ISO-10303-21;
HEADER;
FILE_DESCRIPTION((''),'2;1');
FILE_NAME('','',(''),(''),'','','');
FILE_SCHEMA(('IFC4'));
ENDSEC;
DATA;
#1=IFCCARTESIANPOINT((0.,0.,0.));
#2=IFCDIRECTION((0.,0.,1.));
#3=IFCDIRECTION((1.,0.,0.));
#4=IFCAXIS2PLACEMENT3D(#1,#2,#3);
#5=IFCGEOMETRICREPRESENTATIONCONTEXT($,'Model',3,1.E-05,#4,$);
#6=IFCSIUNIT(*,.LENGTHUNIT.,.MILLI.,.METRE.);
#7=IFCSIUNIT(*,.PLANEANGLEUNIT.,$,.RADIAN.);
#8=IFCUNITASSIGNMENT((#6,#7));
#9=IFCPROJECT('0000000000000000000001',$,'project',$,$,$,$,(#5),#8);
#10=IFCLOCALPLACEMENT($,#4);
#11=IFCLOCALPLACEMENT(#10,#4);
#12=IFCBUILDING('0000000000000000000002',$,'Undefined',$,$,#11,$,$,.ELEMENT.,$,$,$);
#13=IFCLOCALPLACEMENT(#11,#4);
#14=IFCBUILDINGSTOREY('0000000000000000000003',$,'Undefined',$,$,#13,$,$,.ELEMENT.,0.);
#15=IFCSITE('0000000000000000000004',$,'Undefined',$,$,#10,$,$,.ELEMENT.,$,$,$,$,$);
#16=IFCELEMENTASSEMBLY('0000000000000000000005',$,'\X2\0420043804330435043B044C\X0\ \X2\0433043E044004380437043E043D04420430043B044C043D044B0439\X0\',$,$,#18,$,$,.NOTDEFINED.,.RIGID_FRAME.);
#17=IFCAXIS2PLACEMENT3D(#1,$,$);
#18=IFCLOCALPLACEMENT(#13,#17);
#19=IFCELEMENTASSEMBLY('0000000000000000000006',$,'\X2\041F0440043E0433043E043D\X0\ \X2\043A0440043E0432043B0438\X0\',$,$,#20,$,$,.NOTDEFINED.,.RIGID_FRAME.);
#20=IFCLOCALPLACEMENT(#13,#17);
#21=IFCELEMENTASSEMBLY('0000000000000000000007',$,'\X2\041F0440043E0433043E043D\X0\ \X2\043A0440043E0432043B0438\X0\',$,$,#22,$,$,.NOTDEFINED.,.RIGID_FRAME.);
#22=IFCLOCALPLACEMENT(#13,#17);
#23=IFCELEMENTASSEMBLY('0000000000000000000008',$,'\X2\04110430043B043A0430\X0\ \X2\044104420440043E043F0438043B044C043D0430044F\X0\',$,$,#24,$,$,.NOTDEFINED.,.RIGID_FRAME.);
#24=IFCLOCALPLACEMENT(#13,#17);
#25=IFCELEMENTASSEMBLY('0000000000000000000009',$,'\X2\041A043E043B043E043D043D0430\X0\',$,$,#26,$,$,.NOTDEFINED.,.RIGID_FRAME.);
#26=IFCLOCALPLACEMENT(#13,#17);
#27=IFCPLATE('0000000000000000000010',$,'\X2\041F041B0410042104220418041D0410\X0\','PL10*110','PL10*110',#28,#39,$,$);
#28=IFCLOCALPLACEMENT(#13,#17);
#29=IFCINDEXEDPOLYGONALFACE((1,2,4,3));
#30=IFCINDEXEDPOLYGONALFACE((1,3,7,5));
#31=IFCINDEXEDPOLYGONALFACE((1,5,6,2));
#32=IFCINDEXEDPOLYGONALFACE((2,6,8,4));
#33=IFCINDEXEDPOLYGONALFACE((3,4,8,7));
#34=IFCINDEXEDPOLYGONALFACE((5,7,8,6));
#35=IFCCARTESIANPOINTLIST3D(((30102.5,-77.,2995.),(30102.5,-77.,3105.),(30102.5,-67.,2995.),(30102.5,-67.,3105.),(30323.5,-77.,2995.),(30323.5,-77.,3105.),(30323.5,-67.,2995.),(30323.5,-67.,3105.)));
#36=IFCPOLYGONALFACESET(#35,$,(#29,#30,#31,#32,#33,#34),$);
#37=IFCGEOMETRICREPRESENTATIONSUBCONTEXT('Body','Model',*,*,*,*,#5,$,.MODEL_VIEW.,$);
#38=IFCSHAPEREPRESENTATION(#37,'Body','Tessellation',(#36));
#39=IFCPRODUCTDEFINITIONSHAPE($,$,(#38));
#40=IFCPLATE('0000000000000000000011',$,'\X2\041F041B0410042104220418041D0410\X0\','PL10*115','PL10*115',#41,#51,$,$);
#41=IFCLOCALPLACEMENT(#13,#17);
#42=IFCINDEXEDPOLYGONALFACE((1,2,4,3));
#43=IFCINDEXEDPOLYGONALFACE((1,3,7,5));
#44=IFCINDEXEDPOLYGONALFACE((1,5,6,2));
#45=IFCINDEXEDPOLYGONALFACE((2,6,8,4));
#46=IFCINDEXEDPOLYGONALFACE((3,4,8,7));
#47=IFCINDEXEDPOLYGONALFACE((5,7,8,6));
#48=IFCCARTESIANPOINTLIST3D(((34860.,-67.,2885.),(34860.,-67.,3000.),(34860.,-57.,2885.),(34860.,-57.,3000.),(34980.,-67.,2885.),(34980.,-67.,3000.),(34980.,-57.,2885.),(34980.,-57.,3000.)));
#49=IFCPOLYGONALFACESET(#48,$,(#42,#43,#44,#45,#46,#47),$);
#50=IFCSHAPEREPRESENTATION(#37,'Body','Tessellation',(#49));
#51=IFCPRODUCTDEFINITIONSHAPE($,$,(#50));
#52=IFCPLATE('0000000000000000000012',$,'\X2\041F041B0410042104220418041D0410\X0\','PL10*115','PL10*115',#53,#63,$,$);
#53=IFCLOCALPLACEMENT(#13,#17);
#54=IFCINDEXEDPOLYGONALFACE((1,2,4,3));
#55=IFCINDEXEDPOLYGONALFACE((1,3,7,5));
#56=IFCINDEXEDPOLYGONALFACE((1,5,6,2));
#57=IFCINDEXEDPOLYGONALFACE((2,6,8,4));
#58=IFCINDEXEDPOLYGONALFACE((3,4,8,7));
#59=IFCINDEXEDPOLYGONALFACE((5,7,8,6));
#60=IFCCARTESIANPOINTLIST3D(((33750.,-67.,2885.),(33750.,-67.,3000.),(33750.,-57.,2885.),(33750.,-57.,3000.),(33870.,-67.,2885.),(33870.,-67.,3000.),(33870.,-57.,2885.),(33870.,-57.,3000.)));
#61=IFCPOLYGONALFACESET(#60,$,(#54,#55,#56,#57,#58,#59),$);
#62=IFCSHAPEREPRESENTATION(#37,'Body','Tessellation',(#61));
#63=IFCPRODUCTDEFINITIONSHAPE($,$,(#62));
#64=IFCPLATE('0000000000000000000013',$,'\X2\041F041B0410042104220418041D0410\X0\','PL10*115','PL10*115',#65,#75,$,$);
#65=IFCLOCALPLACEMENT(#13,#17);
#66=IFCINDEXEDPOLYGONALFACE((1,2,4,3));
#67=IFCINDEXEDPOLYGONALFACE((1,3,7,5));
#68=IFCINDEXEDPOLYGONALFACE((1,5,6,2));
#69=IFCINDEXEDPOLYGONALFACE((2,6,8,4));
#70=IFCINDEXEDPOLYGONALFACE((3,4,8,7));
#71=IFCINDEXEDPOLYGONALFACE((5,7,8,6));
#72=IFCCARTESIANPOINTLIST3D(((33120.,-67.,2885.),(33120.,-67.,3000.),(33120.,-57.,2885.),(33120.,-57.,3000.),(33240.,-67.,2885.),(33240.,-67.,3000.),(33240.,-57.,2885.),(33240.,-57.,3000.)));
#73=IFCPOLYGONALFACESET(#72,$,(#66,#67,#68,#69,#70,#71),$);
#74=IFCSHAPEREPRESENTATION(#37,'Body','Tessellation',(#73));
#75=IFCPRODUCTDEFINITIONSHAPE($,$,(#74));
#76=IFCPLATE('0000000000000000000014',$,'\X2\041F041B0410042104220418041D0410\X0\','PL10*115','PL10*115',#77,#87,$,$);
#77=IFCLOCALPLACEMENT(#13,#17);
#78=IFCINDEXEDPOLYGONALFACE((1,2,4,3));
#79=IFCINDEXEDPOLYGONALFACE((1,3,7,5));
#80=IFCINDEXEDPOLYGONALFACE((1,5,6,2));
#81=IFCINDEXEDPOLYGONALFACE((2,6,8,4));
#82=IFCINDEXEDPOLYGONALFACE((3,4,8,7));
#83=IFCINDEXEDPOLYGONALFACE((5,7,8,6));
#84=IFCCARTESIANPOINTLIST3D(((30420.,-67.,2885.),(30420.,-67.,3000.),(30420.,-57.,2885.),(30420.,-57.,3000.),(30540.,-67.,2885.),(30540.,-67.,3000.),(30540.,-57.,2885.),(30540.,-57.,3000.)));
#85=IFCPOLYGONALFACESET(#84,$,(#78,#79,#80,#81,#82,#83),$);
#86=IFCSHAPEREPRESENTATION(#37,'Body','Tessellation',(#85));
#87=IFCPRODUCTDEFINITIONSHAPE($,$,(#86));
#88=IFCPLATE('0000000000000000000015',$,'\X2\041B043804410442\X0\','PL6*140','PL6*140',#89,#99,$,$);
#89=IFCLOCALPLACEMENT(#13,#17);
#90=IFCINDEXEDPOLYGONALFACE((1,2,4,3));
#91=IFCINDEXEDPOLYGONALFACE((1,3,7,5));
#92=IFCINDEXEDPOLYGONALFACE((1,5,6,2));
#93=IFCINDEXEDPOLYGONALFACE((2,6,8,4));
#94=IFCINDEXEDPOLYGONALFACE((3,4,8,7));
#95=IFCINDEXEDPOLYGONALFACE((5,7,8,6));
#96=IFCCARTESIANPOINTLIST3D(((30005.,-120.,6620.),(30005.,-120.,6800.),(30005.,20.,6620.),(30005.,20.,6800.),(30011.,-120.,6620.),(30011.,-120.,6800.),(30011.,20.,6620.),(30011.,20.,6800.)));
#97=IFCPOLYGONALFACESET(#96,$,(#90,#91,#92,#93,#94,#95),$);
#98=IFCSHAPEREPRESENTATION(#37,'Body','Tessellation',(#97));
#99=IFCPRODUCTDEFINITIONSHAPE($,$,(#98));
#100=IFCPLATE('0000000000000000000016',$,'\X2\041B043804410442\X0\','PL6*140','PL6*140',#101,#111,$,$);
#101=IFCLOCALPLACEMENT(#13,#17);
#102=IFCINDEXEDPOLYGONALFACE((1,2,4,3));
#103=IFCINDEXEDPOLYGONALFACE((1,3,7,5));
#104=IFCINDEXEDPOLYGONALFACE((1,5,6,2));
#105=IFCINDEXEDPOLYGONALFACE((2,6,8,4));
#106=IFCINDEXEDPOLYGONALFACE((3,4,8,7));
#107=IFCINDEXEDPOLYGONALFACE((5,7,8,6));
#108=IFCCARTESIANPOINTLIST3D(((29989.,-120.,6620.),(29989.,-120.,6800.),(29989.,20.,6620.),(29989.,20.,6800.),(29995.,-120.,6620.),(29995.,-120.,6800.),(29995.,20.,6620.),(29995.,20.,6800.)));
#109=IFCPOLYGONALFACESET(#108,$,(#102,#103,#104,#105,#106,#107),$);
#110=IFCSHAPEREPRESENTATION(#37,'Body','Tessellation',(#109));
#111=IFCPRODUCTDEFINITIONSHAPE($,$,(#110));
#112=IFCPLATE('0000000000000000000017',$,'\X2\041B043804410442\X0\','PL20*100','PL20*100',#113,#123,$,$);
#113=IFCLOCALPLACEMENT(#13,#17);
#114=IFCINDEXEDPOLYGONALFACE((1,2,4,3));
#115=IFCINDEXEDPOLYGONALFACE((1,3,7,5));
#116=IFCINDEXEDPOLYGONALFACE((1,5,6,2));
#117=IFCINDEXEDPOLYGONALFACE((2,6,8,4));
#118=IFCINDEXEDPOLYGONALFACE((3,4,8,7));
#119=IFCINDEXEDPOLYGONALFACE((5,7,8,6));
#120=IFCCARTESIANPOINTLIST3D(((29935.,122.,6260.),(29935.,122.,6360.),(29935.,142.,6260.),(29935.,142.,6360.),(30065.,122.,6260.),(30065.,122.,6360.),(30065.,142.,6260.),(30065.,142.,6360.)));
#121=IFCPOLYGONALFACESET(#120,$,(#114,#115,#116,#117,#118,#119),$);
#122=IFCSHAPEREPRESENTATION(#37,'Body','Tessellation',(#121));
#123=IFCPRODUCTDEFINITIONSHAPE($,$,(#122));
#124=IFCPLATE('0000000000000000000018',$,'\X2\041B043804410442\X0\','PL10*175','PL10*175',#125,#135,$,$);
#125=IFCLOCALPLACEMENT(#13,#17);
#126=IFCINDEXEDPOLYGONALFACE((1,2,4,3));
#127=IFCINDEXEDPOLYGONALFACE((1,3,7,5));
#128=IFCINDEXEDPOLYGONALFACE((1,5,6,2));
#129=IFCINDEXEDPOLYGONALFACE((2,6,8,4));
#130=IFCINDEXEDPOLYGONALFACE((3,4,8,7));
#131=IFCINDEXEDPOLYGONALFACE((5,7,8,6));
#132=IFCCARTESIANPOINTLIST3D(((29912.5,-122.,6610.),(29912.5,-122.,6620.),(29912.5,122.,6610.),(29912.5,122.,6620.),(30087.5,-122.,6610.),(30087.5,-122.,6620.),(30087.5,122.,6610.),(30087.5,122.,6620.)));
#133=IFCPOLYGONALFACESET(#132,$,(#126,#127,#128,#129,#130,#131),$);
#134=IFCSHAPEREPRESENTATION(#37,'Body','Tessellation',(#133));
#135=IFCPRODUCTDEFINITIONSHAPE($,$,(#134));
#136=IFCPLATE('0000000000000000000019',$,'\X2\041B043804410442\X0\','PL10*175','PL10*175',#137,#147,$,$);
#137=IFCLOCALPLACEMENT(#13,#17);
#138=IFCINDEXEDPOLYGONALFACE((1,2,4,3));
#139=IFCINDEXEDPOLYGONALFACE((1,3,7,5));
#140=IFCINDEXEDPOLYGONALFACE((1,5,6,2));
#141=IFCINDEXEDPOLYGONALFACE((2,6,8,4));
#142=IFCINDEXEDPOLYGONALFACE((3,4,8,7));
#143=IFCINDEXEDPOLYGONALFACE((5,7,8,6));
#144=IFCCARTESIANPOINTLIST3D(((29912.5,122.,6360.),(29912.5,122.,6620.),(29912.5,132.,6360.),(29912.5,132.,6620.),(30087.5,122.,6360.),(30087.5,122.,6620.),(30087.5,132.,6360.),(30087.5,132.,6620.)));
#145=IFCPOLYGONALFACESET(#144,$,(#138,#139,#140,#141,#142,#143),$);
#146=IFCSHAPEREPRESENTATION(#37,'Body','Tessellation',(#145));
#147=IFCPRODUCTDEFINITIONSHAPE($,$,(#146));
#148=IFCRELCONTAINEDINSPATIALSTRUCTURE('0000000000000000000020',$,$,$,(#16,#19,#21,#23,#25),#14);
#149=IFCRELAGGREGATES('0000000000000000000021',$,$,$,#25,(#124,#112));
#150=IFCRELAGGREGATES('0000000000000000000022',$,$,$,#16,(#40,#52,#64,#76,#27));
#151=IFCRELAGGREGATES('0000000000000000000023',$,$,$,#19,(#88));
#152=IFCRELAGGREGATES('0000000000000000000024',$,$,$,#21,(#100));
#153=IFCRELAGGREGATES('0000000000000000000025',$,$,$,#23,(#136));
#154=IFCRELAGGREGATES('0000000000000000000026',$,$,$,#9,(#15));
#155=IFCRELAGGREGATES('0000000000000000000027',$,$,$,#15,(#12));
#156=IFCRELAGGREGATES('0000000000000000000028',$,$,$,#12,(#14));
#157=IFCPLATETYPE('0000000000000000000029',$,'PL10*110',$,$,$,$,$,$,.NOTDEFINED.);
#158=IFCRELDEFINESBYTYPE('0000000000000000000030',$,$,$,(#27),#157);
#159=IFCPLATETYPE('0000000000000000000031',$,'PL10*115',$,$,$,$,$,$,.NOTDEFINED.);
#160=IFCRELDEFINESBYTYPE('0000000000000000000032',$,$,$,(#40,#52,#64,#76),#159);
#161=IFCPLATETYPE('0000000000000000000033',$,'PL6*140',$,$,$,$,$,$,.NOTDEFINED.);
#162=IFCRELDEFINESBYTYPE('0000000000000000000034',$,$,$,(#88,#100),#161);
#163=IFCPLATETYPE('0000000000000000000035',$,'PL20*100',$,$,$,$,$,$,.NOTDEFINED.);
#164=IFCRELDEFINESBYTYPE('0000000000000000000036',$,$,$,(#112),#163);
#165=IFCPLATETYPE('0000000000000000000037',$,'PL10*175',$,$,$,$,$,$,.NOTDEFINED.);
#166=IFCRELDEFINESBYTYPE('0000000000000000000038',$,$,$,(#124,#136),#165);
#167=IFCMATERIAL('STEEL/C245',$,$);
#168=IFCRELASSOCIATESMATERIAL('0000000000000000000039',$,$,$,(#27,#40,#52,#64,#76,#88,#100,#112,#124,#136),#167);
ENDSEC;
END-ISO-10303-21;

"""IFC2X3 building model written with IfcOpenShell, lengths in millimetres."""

from ifc_helpers import new_model, si_unit, frame, origin_with_axes, place, context, subcontext, project, spatial, polyline, outline, extrude, material, type_object, element, aggregate, save


model = new_model("IFC2X3")

# Units and contexts
model_context = context("Model", 3, precision=1e-05, world=origin_with_axes())
body_context = subcontext(model_context, "Body", "Model", "MODEL_VIEW")
ifc_project = project(units=[si_unit("LENGTHUNIT", "METRE", prefix="MILLI"), si_unit("PLANEANGLEUNIT", "RADIAN")], contexts=[model_context])

# Site, building, storey
site_placement = place(None, origin_with_axes())
site = spatial("IfcSite", under=ifc_project, at=site_placement, Name="Undefined", CompositionType="ELEMENT")
building_placement = place(site_placement, origin_with_axes())
building = spatial("IfcBuilding", under=site, at=building_placement, Name="Undefined", CompositionType="ELEMENT")
storey_placement = place(building_placement, origin_with_axes())
storey = spatial("IfcBuildingStorey", under=building, at=storey_placement, Name="Undefined", CompositionType="ELEMENT", Elevation=0.0)

# Element assemblies
assembly_1_placement = place(storey_placement, origin_with_axes())
assembly_1 = element("IfcElementAssembly", 1, at=assembly_1_placement, inside=storey, Name="Ригель горизонтальный", AssemblyPlace="NOTDEFINED", PredefinedType="RIGID_FRAME")
ifc_material_1 = material(Name="STEEL/C245")
assembly_2_placement = place(storey_placement, origin_with_axes())
assembly_2 = element("IfcElementAssembly", 2, at=assembly_2_placement, inside=storey, Name="Прогон кровли", AssemblyPlace="NOTDEFINED", PredefinedType="RIGID_FRAME")
assembly_3_placement = place(storey_placement, origin_with_axes())
assembly_3 = element("IfcElementAssembly", 3, at=assembly_3_placement, inside=storey, Name="Прогон кровли", AssemblyPlace="NOTDEFINED", PredefinedType="RIGID_FRAME")

# Element assembly
assembly_4_placement = place(storey_placement, origin_with_axes())
assembly_4 = element("IfcElementAssembly", 4, at=assembly_4_placement, inside=storey, Name="Балка стропильная", AssemblyPlace="NOTDEFINED", PredefinedType="RIGID_FRAME")

# Element assembly
assembly_5_placement = place(storey_placement, origin_with_axes())
assembly_5 = element("IfcElementAssembly", 5, at=assembly_5_placement, inside=storey, Name="Колонна", AssemblyPlace="NOTDEFINED", PredefinedType="RIGID_FRAME")

# Shared definitions
plate_type_1 = type_object("IfcPlateType", Name="PL10*110", PredefinedType="NOTDEFINED")

# Plates
plate_1_placement = place(assembly_1_placement, frame((30102.5, -72.0, 3050.0), z_axis=(0.0, -1.0, 0.0), x_axis=(1.0, 0.0, 0.0)))
plate_1 = element("IfcPlate", 6, at=plate_1_placement, type_object=plate_type_1, material=ifc_material_1, Name="ПЛАСТИНА", Description="PL10*110", ObjectType="PL10*110", context=body_context, shape_type="SweptSolid", body=[
    extrude(outline(polyline([(0.0, -55.0), (0.0, 55.0), (221.0, 55.0), (221.0, -55.0), (0.0, -55.0)])), frame((0.0, 0.0, -5.0), z_axis=(0.0, 0.0, 1.0), x_axis=(1.0, 0.0, 0.0)), (0.0, 0.0, 1.0), 10.0),
])
plate_type_2 = type_object("IfcPlateType", Name="PL10*115", PredefinedType="NOTDEFINED")
plate_2_placement = place(assembly_1_placement, frame((34860.0, -62.0, 3000.0), z_axis=(0.0, -1.0, 0.0), x_axis=(0.0, 0.0, -1.0)))
plate_2 = element("IfcPlate", 7, at=plate_2_placement, type_object=plate_type_2, material=ifc_material_1, Name="ПЛАСТИНА", Description="PL10*115", ObjectType="PL10*115", context=body_context, shape_type="SweptSolid", body=[
    extrude(outline(polyline([(0.0, 0.0), (115.0, 0.0), (115.0, 120.0), (0.0, 120.0), (0.0, 0.0)])), frame((0.0, 0.0, -5.0), z_axis=(0.0, 0.0, 1.0), x_axis=(1.0, 0.0, 0.0)), (0.0, 0.0, 1.0), 10.0),
])
plate_3_placement = place(assembly_1_placement, frame((33750.0, -62.0, 3000.0), z_axis=(0.0, -1.0, 0.0), x_axis=(0.0, 0.0, -1.0)))
plate_3 = element("IfcPlate", 8, at=plate_3_placement, type_object=plate_type_2, material=ifc_material_1, Name="ПЛАСТИНА", Description="PL10*115", ObjectType="PL10*115", context=body_context, shape_type="SweptSolid", body=[
    extrude(outline(polyline([(0.0, 0.0), (115.0, 0.0), (115.0, 120.0), (0.0, 120.0), (0.0, 0.0)])), frame((0.0, 0.0, -5.0), z_axis=(0.0, 0.0, 1.0), x_axis=(1.0, 0.0, 0.0)), (0.0, 0.0, 1.0), 10.0),
])
plate_4_placement = place(assembly_1_placement, frame((33120.0, -62.0, 3000.0), z_axis=(0.0, -1.0, 0.0), x_axis=(0.0, 0.0, -1.0)))
plate_4 = element("IfcPlate", 9, at=plate_4_placement, type_object=plate_type_2, material=ifc_material_1, Name="ПЛАСТИНА", Description="PL10*115", ObjectType="PL10*115", context=body_context, shape_type="SweptSolid", body=[
    extrude(outline(polyline([(0.0, 0.0), (115.0, 0.0), (115.0, 120.0), (0.0, 120.0), (0.0, 0.0)])), frame((0.0, 0.0, -5.0), z_axis=(0.0, 0.0, 1.0), x_axis=(1.0, 0.0, 0.0)), (0.0, 0.0, 1.0), 10.0),
])
plate_5_placement = place(assembly_1_placement, frame((30420.0, -62.0, 3000.0), z_axis=(0.0, -1.0, 0.0), x_axis=(0.0, 0.0, -1.0)))
plate_5 = element("IfcPlate", 10, at=plate_5_placement, type_object=plate_type_2, material=ifc_material_1, Name="ПЛАСТИНА", Description="PL10*115", ObjectType="PL10*115", context=body_context, shape_type="SweptSolid", body=[
    extrude(outline(polyline([(0.0, 0.0), (115.0, 0.0), (115.0, 120.0), (0.0, 120.0), (0.0, 0.0)])), frame((0.0, 0.0, -5.0), z_axis=(0.0, 0.0, 1.0), x_axis=(1.0, 0.0, 0.0)), (0.0, 0.0, 1.0), 10.0),
])
plate_type_3 = type_object("IfcPlateType", Name="PL6*140", PredefinedType="NOTDEFINED")
plate_6_placement = place(assembly_2_placement, frame((30008.0, -50.0, 6620.0), z_axis=(1.0, 0.0, 0.0), x_axis=(0.0, 0.0, 1.0)))
plate_6 = element("IfcPlate", 11, at=plate_6_placement, type_object=plate_type_3, material=ifc_material_1, Name="Лист", Description="PL6*140", ObjectType="PL6*140", context=body_context, shape_type="SweptSolid", body=[
    extrude(outline(polyline([(0.0, 70.0), (180.0, 70.0), (180.0, -70.0), (0.0, -70.0), (0.0, 70.0)])), frame((0.0, 0.0, -3.0), z_axis=(0.0, 0.0, 1.0), x_axis=(1.0, 0.0, 0.0)), (0.0, 0.0, 1.0), 6.0),
])
plate_7_placement = place(assembly_3_placement, frame((29992.0, -50.0, 6620.0), z_axis=(-1.0, 0.0, 0.0), x_axis=(0.0, 0.0, 1.0)))
plate_7 = element("IfcPlate", 12, at=plate_7_placement, type_object=plate_type_3, material=ifc_material_1, Name="Лист", Description="PL6*140", ObjectType="PL6*140", context=body_context, shape_type="SweptSolid", body=[
    extrude(outline(polyline([(0.0, -70.0), (0.0, 70.0), (180.0, 70.0), (180.0, -70.0), (0.0, -70.0)])), frame((0.0, 0.0, -3.0), z_axis=(0.0, 0.0, 1.0), x_axis=(1.0, 0.0, 0.0)), (0.0, 0.0, 1.0), 6.0),
])
plate_type_4 = type_object("IfcPlateType", Name="PL20*100", PredefinedType="NOTDEFINED")
plate_8_placement = place(assembly_5_placement, frame((30065.0, 132.0, 6360.0), z_axis=(0.0, -1.0, 0.0), x_axis=(-1.0, 0.0, 0.0)))
plate_8 = element("IfcPlate", 13, at=plate_8_placement, type_object=plate_type_4, material=ifc_material_1, Name="Лист", Description="PL20*100", ObjectType="PL20*100", context=body_context, shape_type="SweptSolid", body=[
    extrude(outline(polyline([(0.0, 0.0), (130.0, 0.0), (130.0, 100.0), (0.0, 100.0), (0.0, 0.0)])), frame((0.0, 0.0, -10.0), z_axis=(0.0, 0.0, 1.0), x_axis=(1.0, 0.0, 0.0)), (0.0, 0.0, 1.0), 20.0),
])
plate_type_5 = type_object("IfcPlateType", Name="PL10*175", PredefinedType="NOTDEFINED")
plate_9_placement = place(assembly_5_placement, frame((29912.5, 122.0, 6615.0), z_axis=(0.0, 0.0, 1.0), x_axis=(0.0, -1.0, 0.0)))
plate_9 = element("IfcPlate", 14, at=plate_9_placement, type_object=plate_type_5, material=ifc_material_1, Name="Лист", Description="PL10*175", ObjectType="PL10*175", context=body_context, shape_type="SweptSolid", body=[
    extrude(outline(polyline([(0.0, 0.0), (244.0, 0.0), (244.0, 175.0), (0.0, 175.0), (0.0, 0.0)])), frame((0.0, 0.0, -5.0), z_axis=(0.0, 0.0, 1.0), x_axis=(1.0, 0.0, 0.0)), (0.0, 0.0, 1.0), 10.0),
])
aggregate(assembly_5, [plate_9, plate_8])
plate_10_placement = place(assembly_4_placement, frame((30087.5, 127.0, 6620.0), z_axis=(0.0, -1.0, 0.0), x_axis=(-1.0, 0.0, 0.0)))
plate_10 = element("IfcPlate", 15, at=plate_10_placement, type_object=plate_type_5, material=ifc_material_1, Name="Лист", Description="PL10*175", ObjectType="PL10*175", context=body_context, shape_type="SweptSolid", body=[
    extrude(outline(polyline([(0.0, 0.0), (175.0, 0.0), (175.0, 260.0), (0.0, 260.0), (0.0, 0.0)])), frame((0.0, 0.0, -5.0), z_axis=(0.0, 0.0, 1.0), x_axis=(1.0, 0.0, 0.0)), (0.0, 0.0, 1.0), 10.0),
])

aggregate(assembly_1, [plate_2, plate_3, plate_4, plate_5, plate_1])
aggregate(assembly_2, [plate_6])
aggregate(assembly_3, [plate_7])
aggregate(assembly_4, [plate_10])

save(model, "model.ifc")
